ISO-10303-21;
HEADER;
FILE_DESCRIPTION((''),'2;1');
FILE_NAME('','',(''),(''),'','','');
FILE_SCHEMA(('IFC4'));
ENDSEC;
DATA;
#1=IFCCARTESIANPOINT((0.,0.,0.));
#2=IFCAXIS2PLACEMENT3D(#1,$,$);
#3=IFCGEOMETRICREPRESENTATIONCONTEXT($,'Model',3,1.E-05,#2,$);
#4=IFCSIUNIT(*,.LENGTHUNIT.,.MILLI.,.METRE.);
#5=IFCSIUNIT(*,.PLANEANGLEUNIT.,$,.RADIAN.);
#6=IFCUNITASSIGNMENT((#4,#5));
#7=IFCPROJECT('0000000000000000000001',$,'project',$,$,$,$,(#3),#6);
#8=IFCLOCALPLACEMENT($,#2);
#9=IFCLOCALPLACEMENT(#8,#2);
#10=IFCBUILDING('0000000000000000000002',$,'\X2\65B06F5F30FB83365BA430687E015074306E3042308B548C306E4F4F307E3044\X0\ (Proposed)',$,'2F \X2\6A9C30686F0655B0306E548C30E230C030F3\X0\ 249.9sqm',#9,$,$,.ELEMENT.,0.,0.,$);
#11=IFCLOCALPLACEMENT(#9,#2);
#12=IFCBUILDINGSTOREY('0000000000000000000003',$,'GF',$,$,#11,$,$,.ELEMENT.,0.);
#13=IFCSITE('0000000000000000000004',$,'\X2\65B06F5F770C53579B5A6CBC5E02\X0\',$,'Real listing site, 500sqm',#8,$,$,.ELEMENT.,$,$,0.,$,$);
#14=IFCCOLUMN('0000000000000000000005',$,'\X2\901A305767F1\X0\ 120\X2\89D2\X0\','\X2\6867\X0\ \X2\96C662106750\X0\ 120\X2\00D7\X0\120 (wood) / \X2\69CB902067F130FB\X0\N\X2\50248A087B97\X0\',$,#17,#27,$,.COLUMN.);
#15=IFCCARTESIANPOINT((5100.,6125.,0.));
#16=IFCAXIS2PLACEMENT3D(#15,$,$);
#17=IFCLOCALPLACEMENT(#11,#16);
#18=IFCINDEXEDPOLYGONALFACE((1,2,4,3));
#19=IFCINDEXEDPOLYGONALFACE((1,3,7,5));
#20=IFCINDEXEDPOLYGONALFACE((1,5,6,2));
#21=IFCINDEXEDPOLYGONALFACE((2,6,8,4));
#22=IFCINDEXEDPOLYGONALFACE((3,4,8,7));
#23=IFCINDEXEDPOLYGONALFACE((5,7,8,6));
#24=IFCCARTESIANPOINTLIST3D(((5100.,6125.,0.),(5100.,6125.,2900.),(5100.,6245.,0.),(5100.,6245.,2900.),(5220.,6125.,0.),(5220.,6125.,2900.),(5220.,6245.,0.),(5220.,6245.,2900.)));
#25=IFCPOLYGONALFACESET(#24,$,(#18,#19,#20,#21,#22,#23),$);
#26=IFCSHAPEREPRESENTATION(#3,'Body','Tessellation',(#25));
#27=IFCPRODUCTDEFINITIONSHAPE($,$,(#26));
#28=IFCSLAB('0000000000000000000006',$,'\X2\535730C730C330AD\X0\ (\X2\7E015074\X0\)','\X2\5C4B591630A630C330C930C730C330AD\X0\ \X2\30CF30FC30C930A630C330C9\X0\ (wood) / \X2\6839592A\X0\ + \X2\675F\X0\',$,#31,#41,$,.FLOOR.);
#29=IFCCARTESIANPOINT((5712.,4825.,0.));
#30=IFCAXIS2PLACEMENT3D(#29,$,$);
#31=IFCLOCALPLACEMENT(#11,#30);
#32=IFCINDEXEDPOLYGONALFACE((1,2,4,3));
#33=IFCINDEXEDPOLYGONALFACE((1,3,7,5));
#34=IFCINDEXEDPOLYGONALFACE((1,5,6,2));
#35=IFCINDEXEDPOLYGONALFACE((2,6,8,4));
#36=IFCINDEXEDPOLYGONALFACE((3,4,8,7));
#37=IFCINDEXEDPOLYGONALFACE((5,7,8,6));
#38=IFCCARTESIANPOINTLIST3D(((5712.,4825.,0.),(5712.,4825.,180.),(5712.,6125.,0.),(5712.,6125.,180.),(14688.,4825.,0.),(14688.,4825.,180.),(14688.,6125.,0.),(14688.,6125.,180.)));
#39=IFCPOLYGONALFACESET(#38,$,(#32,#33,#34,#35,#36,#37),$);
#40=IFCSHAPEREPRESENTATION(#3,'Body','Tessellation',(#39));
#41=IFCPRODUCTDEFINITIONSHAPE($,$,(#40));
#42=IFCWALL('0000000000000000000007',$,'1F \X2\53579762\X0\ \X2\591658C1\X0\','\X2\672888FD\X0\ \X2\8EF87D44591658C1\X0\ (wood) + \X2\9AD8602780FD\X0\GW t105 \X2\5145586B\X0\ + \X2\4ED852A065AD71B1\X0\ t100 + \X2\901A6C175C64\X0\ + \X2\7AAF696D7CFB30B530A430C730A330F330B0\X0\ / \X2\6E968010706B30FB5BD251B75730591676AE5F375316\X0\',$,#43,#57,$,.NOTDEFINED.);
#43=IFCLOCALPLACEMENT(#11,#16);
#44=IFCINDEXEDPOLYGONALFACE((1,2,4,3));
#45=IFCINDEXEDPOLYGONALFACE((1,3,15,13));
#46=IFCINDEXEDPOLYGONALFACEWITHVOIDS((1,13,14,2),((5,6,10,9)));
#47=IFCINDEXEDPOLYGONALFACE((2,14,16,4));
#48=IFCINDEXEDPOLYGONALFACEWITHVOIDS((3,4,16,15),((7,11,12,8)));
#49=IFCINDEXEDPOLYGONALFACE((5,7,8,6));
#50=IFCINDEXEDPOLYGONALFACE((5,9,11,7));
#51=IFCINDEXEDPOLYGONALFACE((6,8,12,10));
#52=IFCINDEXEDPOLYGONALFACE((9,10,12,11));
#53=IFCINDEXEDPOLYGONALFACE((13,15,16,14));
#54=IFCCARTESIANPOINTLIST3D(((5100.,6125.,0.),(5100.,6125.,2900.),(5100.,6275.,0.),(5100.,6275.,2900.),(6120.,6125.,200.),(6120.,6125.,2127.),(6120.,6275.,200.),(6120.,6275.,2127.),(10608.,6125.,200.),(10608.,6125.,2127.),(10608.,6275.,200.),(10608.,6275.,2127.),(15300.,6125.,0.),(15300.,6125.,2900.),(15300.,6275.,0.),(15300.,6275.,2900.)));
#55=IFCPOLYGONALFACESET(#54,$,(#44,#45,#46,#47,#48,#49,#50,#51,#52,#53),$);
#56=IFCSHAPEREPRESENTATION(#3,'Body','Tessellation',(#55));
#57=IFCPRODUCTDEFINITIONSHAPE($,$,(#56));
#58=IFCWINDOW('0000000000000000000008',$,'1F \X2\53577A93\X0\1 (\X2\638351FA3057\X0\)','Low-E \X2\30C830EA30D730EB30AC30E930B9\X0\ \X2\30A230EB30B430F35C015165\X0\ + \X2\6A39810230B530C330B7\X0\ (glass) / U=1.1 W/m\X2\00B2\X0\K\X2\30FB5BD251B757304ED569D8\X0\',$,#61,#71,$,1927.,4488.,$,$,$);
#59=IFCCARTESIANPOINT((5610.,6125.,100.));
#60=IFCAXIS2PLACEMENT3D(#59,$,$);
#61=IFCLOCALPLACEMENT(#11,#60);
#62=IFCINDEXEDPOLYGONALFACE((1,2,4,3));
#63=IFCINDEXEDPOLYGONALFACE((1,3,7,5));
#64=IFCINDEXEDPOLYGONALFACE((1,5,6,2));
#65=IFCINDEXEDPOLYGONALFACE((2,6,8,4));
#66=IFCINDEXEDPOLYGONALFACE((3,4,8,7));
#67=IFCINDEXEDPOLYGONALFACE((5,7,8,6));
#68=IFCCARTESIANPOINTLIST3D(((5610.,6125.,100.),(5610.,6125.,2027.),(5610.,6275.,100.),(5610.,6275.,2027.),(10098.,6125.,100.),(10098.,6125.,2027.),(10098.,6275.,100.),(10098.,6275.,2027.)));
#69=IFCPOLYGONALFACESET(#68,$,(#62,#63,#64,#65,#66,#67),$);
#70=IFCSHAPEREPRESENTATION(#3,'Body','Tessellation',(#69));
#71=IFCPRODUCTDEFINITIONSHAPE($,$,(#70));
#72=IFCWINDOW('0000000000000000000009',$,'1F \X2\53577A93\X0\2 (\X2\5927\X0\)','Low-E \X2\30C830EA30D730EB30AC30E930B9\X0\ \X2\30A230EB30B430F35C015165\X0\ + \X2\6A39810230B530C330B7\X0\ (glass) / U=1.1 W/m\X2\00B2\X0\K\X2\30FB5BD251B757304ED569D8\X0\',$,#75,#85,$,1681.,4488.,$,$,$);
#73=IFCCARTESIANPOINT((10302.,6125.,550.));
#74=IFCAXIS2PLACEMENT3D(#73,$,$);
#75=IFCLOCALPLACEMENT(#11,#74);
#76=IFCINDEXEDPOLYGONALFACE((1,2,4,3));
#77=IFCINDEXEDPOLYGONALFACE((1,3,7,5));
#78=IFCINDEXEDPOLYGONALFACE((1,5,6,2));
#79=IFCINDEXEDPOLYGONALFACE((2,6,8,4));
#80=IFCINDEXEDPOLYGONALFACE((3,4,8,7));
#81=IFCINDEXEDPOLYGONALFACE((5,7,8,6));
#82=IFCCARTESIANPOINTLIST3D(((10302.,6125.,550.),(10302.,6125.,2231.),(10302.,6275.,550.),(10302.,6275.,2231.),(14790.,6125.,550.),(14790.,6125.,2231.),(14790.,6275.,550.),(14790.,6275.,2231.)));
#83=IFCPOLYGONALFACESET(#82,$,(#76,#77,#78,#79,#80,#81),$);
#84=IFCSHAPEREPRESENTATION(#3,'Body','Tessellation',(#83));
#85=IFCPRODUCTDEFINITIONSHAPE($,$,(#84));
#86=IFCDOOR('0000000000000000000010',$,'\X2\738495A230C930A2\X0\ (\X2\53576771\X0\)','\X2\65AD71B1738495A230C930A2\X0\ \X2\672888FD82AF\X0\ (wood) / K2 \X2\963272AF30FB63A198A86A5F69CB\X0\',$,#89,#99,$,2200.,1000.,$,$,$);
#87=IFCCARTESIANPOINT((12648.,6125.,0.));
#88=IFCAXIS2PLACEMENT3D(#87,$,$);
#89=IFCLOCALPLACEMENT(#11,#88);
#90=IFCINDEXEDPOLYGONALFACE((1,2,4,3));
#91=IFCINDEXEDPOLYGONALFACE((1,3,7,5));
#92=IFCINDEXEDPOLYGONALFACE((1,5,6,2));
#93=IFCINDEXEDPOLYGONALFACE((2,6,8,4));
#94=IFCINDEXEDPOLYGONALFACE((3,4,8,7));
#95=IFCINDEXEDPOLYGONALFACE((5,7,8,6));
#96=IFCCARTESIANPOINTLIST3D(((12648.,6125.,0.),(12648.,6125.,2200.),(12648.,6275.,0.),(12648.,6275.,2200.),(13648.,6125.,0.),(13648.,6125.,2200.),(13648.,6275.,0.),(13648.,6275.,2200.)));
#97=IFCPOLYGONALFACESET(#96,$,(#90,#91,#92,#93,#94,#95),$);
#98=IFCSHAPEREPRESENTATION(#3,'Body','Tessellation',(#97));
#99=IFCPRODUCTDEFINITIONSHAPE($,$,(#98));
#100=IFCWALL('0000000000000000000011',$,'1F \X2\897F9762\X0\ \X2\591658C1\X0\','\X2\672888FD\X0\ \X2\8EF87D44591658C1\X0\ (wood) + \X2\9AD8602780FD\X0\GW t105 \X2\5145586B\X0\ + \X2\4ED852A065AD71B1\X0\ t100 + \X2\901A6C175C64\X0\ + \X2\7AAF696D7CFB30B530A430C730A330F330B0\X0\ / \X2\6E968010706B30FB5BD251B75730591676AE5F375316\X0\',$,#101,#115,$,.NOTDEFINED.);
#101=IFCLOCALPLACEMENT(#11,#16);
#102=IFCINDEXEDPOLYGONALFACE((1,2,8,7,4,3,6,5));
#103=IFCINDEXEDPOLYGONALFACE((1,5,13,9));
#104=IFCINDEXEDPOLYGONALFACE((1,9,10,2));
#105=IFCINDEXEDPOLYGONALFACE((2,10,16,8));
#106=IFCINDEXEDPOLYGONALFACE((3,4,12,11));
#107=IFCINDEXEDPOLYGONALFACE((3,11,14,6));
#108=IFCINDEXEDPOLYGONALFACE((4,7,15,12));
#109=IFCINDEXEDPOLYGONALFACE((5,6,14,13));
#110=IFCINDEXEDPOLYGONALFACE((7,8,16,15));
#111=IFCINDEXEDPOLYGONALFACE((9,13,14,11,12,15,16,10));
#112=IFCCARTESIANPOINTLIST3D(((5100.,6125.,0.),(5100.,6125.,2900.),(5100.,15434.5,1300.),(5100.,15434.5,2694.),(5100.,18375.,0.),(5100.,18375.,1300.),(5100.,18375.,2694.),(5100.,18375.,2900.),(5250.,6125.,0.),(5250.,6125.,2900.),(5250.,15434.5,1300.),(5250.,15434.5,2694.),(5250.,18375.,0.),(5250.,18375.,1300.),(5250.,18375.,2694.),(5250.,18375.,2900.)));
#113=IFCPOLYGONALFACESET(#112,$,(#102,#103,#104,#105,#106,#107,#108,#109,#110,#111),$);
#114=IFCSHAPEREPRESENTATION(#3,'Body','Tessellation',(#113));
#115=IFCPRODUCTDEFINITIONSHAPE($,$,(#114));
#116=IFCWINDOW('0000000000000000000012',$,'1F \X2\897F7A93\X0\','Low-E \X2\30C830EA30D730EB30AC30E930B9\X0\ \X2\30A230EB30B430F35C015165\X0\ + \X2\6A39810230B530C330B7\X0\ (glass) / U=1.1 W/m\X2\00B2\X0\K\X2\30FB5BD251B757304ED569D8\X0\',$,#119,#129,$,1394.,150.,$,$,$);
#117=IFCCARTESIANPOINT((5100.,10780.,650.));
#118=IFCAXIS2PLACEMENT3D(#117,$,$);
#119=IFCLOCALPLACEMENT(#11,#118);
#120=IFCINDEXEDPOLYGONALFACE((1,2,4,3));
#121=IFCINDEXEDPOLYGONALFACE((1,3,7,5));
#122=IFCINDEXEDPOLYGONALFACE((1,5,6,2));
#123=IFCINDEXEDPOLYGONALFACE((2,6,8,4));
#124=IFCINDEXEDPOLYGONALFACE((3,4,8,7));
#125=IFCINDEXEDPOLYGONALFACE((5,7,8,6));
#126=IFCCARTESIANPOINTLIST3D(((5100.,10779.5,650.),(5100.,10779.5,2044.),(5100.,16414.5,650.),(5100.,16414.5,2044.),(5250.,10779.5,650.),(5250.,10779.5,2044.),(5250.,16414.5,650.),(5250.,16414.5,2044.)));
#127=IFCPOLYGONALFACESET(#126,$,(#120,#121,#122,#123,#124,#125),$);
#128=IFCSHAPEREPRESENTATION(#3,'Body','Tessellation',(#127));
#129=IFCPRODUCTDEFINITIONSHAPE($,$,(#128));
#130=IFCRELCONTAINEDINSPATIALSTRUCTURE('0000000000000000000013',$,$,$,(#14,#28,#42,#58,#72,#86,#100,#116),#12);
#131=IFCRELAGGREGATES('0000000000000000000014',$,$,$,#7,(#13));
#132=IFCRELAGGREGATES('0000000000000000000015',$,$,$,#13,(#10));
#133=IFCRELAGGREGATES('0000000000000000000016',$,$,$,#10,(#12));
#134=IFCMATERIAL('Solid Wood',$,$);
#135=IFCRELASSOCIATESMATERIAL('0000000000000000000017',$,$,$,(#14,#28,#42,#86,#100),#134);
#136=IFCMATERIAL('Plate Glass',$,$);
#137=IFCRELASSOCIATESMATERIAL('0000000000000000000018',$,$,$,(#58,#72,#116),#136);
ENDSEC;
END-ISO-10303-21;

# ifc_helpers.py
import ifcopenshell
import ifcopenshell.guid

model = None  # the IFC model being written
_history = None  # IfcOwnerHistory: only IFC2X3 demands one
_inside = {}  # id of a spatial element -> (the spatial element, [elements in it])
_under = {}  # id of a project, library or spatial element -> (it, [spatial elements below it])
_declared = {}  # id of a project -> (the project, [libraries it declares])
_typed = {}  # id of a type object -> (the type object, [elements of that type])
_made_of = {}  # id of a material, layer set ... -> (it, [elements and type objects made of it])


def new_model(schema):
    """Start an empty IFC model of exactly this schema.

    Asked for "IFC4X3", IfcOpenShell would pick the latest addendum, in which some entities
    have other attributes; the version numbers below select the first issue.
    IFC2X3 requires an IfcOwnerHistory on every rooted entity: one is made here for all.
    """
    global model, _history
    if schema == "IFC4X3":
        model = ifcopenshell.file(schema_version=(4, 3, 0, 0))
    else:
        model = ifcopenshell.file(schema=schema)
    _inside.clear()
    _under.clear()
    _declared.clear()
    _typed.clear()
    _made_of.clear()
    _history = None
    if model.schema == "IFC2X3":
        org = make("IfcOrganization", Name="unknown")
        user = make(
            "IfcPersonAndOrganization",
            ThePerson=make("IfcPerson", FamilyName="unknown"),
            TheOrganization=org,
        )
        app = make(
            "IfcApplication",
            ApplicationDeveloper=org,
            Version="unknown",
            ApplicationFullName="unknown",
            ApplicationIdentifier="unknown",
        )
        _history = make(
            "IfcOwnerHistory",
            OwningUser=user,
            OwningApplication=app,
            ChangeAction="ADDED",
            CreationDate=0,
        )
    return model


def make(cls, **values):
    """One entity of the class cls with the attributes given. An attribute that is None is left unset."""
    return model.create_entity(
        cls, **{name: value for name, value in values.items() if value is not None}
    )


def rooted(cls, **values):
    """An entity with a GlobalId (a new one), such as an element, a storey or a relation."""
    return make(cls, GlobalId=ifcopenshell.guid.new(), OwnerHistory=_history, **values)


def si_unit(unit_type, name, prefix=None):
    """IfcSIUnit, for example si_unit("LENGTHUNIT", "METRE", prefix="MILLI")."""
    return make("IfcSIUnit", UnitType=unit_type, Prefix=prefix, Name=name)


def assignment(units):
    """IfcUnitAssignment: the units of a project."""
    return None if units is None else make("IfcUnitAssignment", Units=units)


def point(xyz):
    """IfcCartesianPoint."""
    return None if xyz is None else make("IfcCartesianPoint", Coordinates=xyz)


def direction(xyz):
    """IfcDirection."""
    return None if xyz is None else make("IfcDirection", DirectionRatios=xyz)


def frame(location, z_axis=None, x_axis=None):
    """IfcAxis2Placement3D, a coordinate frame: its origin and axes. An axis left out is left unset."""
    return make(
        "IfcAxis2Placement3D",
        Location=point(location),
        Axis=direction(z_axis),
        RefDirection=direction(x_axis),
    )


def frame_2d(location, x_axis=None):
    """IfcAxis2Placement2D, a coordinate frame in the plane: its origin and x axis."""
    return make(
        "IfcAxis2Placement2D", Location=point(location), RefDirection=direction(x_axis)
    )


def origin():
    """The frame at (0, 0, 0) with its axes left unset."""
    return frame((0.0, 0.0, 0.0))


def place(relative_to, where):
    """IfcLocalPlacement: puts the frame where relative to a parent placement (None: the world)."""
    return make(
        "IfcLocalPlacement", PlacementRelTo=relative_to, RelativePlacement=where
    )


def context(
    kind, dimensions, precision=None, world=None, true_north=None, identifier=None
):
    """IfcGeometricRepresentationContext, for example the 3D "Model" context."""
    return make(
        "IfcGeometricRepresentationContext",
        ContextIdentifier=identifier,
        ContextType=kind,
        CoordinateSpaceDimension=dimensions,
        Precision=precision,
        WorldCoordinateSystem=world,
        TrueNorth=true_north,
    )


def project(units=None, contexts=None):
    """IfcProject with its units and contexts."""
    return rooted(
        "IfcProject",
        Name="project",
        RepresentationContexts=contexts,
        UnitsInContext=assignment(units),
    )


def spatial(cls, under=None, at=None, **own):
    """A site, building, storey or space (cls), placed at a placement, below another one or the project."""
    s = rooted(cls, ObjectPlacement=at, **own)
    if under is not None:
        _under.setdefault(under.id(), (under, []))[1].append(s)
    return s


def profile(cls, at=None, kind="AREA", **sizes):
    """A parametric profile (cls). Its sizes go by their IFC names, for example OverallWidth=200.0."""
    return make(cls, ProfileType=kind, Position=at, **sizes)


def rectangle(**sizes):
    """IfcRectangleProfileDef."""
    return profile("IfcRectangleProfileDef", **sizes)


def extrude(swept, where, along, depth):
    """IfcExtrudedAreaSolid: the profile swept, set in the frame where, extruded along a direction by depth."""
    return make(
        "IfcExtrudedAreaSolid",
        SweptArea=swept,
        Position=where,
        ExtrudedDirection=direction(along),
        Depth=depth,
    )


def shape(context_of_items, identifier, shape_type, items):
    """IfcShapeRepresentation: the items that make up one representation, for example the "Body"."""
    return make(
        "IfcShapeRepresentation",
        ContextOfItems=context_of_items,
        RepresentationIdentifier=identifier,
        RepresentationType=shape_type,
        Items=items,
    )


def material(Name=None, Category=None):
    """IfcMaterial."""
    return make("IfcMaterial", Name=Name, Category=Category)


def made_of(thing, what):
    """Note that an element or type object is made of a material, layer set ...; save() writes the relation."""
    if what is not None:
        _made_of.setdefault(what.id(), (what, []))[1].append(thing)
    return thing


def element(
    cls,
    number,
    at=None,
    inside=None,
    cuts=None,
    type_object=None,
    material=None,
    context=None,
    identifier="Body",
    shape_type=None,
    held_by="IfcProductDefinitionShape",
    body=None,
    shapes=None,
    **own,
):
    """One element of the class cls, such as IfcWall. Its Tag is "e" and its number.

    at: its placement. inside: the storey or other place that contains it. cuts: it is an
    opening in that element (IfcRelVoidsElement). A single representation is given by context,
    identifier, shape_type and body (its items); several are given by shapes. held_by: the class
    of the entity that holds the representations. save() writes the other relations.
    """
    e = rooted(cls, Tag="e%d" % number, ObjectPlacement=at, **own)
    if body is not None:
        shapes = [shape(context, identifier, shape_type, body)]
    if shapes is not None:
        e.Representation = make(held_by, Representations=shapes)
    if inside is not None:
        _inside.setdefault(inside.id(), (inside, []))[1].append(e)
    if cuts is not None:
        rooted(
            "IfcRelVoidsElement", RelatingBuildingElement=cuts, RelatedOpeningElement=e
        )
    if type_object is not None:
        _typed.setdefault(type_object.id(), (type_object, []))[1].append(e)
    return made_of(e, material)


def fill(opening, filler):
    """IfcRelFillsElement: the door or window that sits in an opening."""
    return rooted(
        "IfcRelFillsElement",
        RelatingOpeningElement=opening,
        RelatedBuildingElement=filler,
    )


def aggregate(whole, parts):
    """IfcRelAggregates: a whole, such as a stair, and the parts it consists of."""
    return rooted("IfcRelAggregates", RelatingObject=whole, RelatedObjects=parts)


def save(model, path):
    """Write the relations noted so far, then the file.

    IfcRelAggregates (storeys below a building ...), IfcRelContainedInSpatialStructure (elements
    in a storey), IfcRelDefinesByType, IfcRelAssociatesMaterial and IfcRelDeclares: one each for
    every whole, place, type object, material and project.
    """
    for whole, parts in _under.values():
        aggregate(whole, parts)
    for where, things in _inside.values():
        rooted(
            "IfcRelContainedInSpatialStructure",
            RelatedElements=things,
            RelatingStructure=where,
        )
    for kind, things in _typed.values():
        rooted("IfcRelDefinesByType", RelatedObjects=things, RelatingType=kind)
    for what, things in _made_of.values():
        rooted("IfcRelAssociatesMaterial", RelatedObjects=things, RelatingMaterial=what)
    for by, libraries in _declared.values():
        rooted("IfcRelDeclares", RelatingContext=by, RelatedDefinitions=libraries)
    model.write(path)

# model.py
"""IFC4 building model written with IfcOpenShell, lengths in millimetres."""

from ifc_helpers import new_model, si_unit, frame, frame_2d, origin, place, context, project, spatial, rectangle, extrude, material, element, fill, save


model = new_model("IFC4")

# Units and contexts
model_context = context("Model", 3, precision=1e-05, world=origin())
ifc_project = project(units=[si_unit("LENGTHUNIT", "METRE", prefix="MILLI"), si_unit("PLANEANGLEUNIT", "RADIAN")], contexts=[model_context])

# Site, building, storey
site_placement = place(None, origin())
site = spatial("IfcSite", under=ifc_project, at=site_placement, Name="新潟県南魚沼市", ObjectType="Real listing site, 500sqm", CompositionType="ELEMENT", RefElevation=0.0)
building_placement = place(site_placement, origin())
building = spatial("IfcBuilding", under=site, at=building_placement, Name="新潟・茶室と縁側のある和の住まい (Proposed)", ObjectType="2F 檜と漆喰の和モダン 249.9sqm", CompositionType="ELEMENT", ElevationOfRefHeight=0.0, ElevationOfTerrain=0.0)
storey_placement = place(building_placement, origin())
storey = spatial("IfcBuildingStorey", under=building, at=storey_placement, Name="GF", CompositionType="ELEMENT", Elevation=0.0)

# Column
ifc_material_1 = material(Name="Solid Wood")
column_placement = place(storey_placement, frame((5100.0, 6125.0, 0.0)))
element("IfcColumn", 1, at=column_placement, inside=storey, material=ifc_material_1, Name="通し柱 120角", Description="桧 集成材 120×120 (wood) / 構造柱・N値計算", PredefinedType="COLUMN", context=model_context, shape_type="SweptSolid", body=[
    extrude(rectangle(XDim=120.0, YDim=120.0, at=frame_2d((60.0, 60.0))), frame((5100.0, 6125.0, 0.0)), (0.0, 0.0, 1.0), 2900.0),
])

# Slab
slab_1_placement = place(storey_placement, frame((5712.0, 4825.0, 0.0)))
element("IfcSlab", 2, at=slab_1_placement, inside=storey, material=ifc_material_1, Name="南デッキ (縁側)", Description="屋外ウッドデッキ ハードウッド (wood) / 根太 + 束", PredefinedType="FLOOR", context=model_context, shape_type="SweptSolid", body=[
    extrude(rectangle(XDim=8976.0, YDim=1300.0, at=frame_2d((4488.0, 650.0))), frame((5712.0, 4825.0, 0.0)), (0.0, 0.0, 1.0), 180.0),
])

# Wall, openings, windows, door
wall_1_placement = place(storey_placement, frame((5100.0, 6125.0, 0.0)))
wall_1 = element("IfcWall", 3, at=wall_1_placement, inside=storey, material=ifc_material_1, Name="1F 南面 外壁", Description="木製 軸組外壁 (wood) + 高性能GW t105 充填 + 付加断熱 t100 + 通気層 + 窯業系サイディング / 準耐火・寒冷地外皮強化", PredefinedType="NOTDEFINED", context=model_context, shape_type="SweptSolid", body=[
    extrude(rectangle(XDim=10200.0, YDim=150.0, at=frame_2d((5100.0, 75.0))), frame((5100.0, 6125.0, 0.0)), (0.0, 0.0, 1.0), 2900.0),
])
opening_1_placement = place(storey_placement, frame((5610.0, 6125.0, 100.0)))
opening_1 = element("IfcOpeningElement", 4, at=opening_1_placement, cuts=wall_1, PredefinedType="NOTDEFINED", context=model_context, shape_type="SweptSolid", body=[
    extrude(rectangle(XDim=4488.0, YDim=150.0, at=frame_2d((2244.0, 75.0))), frame((5610.0, 6125.0, 100.0)), (0.0, 0.0, 1.0), 1927.0),
])
opening_2_placement = place(storey_placement, frame((10302.0, 6125.0, 550.0)))
opening_2 = element("IfcOpeningElement", 5, at=opening_2_placement, cuts=wall_1, PredefinedType="NOTDEFINED", context=model_context, shape_type="SweptSolid", body=[
    extrude(rectangle(XDim=4488.0, YDim=150.0, at=frame_2d((2244.0, 75.0))), frame((10302.0, 6125.0, 550.0)), (0.0, 0.0, 1.0), 1681.0),
])
opening_3_placement = place(storey_placement, frame((12648.0, 6125.0, 0.0)))
opening_3 = element("IfcOpeningElement", 6, at=opening_3_placement, cuts=wall_1, PredefinedType="NOTDEFINED", context=model_context, shape_type="SweptSolid", body=[
    extrude(rectangle(XDim=1000.0, YDim=150.0, at=frame_2d((500.0, 75.0))), frame((12648.0, 6125.0, 0.0)), (0.0, 0.0, 1.0), 2200.0),
])
ifc_material_2 = material(Name="Plate Glass")
window_1_placement = place(storey_placement, frame((5610.0, 6125.0, 100.0)))
window_1 = element("IfcWindow", 7, at=window_1_placement, inside=storey, material=ifc_material_2, Name="1F 南窓1 (掃出し)", Description="Low-E トリプルガラス アルゴン封入 + 樹脂サッシ (glass) / U=1.1 W/m²K・寒冷地仕様", OverallHeight=1927.0, OverallWidth=4488.0, context=model_context, shape_type="SweptSolid", body=[
    extrude(rectangle(XDim=4488.0, YDim=150.0, at=frame_2d((2244.0, 75.0))), frame((5610.0, 6125.0, 100.0)), (0.0, 0.0, 1.0), 1927.0),
])
fill(opening_1, window_1)
window_2_placement = place(storey_placement, frame((10302.0, 6125.0, 550.0)))
window_2 = element("IfcWindow", 8, at=window_2_placement, inside=storey, material=ifc_material_2, Name="1F 南窓2 (大)", Description="Low-E トリプルガラス アルゴン封入 + 樹脂サッシ (glass) / U=1.1 W/m²K・寒冷地仕様", OverallHeight=1681.0, OverallWidth=4488.0, context=model_context, shape_type="SweptSolid", body=[
    extrude(rectangle(XDim=4488.0, YDim=150.0, at=frame_2d((2244.0, 75.0))), frame((10302.0, 6125.0, 550.0)), (0.0, 0.0, 1.0), 1681.0),
])
fill(opening_2, window_2)
door_placement = place(storey_placement, frame((12648.0, 6125.0, 0.0)))
door = element("IfcDoor", 9, at=door_placement, inside=storey, material=ifc_material_1, Name="玄関ドア (南東)", Description="断熱玄関ドア 木製芯 (wood) / K2 防犯・採風機構", OverallHeight=2200.0, OverallWidth=1000.0, context=model_context, shape_type="SweptSolid", body=[
    extrude(rectangle(XDim=1000.0, YDim=150.0, at=frame_2d((500.0, 75.0))), frame((12648.0, 6125.0, 0.0)), (0.0, 0.0, 1.0), 2200.0),
])
fill(opening_3, door)

# Wall, opening, window
wall_2_placement = place(storey_placement, frame((5100.0, 6125.0, 0.0)))
wall_2 = element("IfcWall", 10, at=wall_2_placement, inside=storey, material=ifc_material_1, Name="1F 西面 外壁", Description="木製 軸組外壁 (wood) + 高性能GW t105 充填 + 付加断熱 t100 + 通気層 + 窯業系サイディング / 準耐火・寒冷地外皮強化", PredefinedType="NOTDEFINED", context=model_context, shape_type="SweptSolid", body=[
    extrude(rectangle(XDim=150.0, YDim=12250.0, at=frame_2d((75.0, 6125.0))), frame((5100.0, 6125.0, 0.0)), (0.0, 0.0, 1.0), 2900.0),
])
opening_4_placement = place(storey_placement, frame((5100.0, 10780.0, 650.0)))
opening_4 = element("IfcOpeningElement", 11, at=opening_4_placement, cuts=wall_2, PredefinedType="NOTDEFINED", context=model_context, shape_type="SweptSolid", body=[
    extrude(rectangle(XDim=150.0, YDim=5635.0, at=frame_2d((75.0, 2817.0))), frame((5100.0, 10780.0, 650.0)), (0.0, 0.0, 1.0), 1394.0),
])
window_3_placement = place(storey_placement, frame((5100.0, 10780.0, 650.0)))
window_3 = element("IfcWindow", 12, at=window_3_placement, inside=storey, material=ifc_material_2, Name="1F 西窓", Description="Low-E トリプルガラス アルゴン封入 + 樹脂サッシ (glass) / U=1.1 W/m²K・寒冷地仕様", OverallHeight=1394.0, OverallWidth=150.0, context=model_context, shape_type="SweptSolid", body=[
    extrude(rectangle(XDim=150.0, YDim=5635.0, at=frame_2d((75.0, 2817.0))), frame((5100.0, 10780.0, 650.0)), (0.0, 0.0, 1.0), 1394.0),
])
fill(opening_4, window_3)

save(model, "model.ifc")
